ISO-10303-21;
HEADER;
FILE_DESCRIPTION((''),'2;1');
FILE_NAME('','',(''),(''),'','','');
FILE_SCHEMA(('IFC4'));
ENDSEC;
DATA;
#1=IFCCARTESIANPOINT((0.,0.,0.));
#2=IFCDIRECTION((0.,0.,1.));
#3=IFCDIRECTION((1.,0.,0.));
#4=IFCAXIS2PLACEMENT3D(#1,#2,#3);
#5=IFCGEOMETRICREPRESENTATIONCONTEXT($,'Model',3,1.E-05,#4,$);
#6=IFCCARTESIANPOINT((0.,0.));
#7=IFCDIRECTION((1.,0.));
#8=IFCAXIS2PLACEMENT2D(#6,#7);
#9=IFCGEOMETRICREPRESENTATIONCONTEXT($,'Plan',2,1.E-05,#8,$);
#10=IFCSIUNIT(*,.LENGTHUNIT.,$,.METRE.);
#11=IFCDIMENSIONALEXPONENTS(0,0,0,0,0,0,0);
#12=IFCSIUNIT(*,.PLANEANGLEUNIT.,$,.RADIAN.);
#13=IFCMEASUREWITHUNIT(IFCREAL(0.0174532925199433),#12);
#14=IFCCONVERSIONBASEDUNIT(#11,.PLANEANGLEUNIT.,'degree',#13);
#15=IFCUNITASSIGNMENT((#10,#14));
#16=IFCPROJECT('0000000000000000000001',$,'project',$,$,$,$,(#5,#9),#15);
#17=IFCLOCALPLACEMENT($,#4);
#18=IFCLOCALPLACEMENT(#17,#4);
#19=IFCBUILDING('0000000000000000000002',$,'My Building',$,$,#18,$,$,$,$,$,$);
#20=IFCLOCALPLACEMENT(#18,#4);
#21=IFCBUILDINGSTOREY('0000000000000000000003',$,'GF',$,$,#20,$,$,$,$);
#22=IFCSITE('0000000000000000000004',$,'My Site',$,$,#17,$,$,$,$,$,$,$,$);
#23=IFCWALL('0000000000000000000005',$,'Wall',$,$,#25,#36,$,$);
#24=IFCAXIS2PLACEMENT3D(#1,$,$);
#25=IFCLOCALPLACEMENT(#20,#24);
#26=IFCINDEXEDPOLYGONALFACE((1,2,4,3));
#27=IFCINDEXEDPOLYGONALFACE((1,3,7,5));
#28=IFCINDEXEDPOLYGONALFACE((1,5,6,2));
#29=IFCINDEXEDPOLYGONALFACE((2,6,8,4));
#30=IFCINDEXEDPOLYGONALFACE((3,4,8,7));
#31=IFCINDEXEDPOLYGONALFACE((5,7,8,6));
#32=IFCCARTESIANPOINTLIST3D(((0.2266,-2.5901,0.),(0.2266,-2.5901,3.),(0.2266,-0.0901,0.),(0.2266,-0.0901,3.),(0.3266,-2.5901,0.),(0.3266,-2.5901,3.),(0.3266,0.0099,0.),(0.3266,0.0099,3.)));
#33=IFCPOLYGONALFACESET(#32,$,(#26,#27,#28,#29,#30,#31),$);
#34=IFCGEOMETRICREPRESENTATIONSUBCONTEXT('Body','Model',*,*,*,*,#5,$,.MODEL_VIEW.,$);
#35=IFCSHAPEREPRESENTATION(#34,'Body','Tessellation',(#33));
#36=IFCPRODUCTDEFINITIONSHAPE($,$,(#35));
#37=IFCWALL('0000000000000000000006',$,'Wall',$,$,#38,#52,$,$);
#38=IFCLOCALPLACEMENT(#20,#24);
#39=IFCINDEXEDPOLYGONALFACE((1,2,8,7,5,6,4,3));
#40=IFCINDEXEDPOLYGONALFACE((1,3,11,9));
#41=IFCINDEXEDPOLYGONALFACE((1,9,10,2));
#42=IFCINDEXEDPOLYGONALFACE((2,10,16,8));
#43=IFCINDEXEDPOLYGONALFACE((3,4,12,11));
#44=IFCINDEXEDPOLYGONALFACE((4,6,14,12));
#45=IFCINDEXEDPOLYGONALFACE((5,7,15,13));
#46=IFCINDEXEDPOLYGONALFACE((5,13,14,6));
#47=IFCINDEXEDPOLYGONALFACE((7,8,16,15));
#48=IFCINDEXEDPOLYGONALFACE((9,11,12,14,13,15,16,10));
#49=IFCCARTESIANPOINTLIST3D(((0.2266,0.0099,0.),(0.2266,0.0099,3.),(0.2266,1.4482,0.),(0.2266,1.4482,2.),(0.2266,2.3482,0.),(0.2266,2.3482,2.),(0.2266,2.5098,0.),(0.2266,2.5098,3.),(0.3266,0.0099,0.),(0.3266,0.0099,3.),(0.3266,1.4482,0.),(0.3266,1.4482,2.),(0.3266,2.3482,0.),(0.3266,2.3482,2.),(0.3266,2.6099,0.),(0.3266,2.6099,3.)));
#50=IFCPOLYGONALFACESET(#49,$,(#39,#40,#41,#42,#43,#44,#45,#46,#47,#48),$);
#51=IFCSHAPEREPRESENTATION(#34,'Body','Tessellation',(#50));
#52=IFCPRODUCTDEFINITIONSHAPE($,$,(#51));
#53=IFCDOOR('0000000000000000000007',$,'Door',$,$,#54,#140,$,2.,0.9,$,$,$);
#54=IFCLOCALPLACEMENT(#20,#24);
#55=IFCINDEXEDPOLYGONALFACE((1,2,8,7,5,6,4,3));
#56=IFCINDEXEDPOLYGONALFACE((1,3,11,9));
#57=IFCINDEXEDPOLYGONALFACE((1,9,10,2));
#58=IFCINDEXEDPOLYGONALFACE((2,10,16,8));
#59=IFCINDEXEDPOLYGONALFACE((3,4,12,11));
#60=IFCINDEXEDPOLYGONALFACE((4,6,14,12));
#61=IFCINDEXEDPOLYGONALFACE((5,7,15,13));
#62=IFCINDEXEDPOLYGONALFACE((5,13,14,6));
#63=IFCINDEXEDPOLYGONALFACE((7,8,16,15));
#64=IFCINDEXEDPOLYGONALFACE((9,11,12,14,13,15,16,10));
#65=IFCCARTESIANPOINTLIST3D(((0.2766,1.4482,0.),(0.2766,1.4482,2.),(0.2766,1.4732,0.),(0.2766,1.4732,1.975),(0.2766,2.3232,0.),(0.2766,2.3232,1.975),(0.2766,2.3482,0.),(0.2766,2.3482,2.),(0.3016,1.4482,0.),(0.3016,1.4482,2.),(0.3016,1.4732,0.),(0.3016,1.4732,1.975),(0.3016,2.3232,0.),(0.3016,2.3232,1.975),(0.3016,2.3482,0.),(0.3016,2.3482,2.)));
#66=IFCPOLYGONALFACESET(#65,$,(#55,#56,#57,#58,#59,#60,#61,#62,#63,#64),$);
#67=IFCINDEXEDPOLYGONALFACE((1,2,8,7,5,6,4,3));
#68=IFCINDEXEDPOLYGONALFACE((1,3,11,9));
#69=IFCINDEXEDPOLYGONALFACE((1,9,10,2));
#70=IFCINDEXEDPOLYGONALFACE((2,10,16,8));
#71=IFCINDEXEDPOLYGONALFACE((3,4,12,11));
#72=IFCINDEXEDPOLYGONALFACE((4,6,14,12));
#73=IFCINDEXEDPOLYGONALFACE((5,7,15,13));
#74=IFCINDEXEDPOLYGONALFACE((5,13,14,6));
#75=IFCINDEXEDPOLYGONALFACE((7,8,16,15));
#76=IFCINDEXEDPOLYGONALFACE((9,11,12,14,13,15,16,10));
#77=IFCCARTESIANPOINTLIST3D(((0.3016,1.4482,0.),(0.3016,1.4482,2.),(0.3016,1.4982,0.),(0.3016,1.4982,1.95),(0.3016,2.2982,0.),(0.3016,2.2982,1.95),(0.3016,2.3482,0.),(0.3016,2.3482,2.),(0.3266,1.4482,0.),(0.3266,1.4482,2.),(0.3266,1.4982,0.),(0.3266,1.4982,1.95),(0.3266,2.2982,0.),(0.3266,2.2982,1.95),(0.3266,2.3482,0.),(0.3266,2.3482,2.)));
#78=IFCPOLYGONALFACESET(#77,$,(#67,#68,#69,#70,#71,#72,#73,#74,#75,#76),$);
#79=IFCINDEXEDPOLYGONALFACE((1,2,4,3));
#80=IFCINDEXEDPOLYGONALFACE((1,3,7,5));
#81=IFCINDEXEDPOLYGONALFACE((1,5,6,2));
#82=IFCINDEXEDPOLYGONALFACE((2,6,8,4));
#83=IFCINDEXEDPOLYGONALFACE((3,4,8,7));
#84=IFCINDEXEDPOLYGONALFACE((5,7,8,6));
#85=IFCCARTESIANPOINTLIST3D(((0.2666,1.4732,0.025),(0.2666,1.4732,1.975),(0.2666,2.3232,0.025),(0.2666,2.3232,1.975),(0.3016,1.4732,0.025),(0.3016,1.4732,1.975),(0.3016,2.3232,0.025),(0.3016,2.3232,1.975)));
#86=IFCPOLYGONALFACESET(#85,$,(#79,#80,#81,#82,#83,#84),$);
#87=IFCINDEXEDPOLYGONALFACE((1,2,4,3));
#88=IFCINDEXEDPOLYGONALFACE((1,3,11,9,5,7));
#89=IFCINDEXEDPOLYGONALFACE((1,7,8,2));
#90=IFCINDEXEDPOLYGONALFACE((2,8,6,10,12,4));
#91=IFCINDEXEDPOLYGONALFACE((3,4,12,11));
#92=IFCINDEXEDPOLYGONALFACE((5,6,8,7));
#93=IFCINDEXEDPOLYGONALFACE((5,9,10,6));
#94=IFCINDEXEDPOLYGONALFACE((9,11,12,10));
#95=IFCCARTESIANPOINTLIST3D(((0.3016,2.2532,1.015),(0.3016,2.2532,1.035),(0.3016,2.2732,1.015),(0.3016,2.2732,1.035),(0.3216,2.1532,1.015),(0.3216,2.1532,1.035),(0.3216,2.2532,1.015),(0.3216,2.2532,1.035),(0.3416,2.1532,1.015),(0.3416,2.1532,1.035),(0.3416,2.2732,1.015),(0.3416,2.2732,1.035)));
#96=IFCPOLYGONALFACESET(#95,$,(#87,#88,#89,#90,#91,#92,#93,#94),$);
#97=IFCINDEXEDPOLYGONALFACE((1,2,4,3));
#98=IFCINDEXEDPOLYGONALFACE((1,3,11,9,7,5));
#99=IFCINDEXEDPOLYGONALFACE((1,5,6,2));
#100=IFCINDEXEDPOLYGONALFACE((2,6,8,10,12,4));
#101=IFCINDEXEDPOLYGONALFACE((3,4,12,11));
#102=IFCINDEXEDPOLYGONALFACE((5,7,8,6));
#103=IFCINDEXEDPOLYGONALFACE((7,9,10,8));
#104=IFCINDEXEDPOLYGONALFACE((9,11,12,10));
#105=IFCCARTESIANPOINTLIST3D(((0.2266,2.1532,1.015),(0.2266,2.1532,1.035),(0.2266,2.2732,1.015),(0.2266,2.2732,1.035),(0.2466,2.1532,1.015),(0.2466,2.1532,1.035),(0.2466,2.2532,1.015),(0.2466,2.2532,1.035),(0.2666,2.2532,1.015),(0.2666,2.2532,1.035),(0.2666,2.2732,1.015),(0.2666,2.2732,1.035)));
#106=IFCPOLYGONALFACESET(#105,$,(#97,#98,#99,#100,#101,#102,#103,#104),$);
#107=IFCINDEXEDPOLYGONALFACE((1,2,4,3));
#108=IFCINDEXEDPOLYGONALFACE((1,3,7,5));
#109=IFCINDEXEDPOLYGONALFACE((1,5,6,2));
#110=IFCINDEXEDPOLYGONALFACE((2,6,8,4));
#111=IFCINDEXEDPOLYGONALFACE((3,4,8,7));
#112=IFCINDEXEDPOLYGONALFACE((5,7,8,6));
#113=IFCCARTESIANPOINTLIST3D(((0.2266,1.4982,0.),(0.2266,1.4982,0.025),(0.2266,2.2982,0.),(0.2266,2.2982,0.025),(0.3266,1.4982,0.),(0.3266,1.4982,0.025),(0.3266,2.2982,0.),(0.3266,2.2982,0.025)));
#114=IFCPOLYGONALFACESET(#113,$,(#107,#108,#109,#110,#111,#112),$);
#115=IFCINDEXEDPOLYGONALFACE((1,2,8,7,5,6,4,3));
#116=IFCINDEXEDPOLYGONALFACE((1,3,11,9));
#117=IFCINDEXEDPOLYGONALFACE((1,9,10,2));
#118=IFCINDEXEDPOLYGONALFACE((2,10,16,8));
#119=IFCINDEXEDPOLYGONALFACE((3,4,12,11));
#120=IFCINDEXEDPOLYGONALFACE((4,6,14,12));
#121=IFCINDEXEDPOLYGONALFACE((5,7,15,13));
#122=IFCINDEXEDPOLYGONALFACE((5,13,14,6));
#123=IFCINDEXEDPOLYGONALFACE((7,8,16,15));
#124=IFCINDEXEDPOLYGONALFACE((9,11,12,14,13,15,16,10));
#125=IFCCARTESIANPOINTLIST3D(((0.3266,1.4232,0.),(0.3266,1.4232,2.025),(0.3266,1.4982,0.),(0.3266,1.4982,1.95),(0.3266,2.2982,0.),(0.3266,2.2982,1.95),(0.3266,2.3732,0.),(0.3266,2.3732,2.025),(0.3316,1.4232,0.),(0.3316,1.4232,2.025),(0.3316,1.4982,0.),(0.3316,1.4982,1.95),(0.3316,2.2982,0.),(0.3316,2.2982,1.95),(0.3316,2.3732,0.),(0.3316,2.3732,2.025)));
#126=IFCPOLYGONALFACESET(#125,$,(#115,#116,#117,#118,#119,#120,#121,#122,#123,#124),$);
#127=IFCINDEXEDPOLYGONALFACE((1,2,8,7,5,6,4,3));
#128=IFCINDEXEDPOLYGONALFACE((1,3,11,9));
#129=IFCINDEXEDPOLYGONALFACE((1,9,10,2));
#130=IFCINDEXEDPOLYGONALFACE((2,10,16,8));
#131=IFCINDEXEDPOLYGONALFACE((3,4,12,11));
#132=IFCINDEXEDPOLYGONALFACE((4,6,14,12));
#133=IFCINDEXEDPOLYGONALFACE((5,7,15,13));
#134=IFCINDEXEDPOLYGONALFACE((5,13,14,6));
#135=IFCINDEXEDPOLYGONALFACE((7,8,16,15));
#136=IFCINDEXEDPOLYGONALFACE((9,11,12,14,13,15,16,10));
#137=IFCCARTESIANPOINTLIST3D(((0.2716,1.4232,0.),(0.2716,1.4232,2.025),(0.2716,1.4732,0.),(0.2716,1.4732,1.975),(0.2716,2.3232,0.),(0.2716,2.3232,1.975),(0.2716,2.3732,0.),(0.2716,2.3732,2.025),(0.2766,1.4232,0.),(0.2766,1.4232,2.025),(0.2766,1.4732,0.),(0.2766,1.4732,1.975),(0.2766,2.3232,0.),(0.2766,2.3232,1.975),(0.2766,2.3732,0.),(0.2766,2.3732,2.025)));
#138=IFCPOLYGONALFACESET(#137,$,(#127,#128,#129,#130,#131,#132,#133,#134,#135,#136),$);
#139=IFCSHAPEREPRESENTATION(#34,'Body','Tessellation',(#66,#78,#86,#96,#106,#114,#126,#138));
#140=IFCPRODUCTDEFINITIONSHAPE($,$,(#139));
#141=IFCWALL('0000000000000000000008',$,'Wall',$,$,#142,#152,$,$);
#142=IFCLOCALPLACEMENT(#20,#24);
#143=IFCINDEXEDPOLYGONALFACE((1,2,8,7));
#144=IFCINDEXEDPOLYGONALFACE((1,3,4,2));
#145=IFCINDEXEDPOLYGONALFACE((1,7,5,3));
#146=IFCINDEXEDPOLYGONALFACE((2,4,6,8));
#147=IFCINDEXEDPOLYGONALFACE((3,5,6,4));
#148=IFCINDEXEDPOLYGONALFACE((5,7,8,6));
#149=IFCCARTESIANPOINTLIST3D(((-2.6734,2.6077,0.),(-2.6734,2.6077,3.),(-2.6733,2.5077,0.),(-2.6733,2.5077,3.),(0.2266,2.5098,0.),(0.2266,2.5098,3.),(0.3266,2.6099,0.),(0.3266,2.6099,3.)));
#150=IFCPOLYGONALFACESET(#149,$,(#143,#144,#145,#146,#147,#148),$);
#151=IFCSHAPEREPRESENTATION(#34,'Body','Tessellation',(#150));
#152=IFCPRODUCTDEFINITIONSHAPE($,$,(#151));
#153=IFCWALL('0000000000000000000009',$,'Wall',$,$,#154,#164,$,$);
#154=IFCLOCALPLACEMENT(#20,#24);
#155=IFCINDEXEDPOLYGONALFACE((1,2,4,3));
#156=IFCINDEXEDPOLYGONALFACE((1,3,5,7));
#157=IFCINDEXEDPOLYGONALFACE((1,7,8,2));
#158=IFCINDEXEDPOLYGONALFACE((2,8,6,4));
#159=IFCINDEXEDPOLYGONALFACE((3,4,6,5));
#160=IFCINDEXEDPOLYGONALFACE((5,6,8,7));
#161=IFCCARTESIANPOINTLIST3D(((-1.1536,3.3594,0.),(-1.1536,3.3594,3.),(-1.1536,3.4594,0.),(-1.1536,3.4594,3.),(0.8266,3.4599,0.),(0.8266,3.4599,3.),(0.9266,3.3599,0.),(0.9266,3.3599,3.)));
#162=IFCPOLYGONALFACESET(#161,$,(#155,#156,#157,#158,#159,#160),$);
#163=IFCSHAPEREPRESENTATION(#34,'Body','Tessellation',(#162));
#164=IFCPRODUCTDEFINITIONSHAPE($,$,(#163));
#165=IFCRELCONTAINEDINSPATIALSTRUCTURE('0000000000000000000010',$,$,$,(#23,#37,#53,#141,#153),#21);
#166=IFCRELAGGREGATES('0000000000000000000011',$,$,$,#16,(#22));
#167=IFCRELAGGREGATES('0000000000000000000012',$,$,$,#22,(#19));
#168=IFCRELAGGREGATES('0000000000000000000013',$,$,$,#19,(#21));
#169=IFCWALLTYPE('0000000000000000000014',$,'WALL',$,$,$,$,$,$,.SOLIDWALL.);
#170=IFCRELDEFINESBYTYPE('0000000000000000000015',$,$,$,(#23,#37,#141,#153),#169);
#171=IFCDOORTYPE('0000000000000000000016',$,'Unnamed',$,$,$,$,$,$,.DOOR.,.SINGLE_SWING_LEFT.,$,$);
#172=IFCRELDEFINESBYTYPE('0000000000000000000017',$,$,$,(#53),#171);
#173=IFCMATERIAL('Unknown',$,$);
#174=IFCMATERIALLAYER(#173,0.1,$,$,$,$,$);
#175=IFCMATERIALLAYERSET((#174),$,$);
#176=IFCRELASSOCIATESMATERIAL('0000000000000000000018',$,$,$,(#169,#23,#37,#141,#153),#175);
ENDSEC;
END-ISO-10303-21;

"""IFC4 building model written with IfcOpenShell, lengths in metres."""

from ifc_helpers import new_model, entity, si_unit, converted_unit, frame, origin_with_axes, origin_2d_with_axis, place, context, subcontext, project, spatial, line, indexed_curve, outline, extrude, shape, source, transform, mapped, material, layer, layer_set, layer_usage, type_object, type_shapes, element, fill, save


model = new_model("IFC4")

# Units and contexts
model_context = context("Model", 3, precision=1e-05, world=origin_with_axes())
plan_context = context("Plan", 2, precision=1e-05, world=origin_2d_with_axis())
body_context_1 = subcontext(model_context, "Body", "Model", "MODEL_VIEW")
body_context_2 = subcontext(plan_context, "Body", "Plan", "PLAN_VIEW")
ifc_project = project(units=[si_unit("LENGTHUNIT", "METRE"), converted_unit("PLANEANGLEUNIT", "degree", entity("IfcReal", 0.0174532925199433), si_unit("PLANEANGLEUNIT", "RADIAN"), dimensions=[0, 0, 0, 0, 0, 0, 0])], contexts=[model_context, plan_context])

# Site, building, storey
site_placement = place(None, origin_with_axes())
site = spatial("IfcSite", under=ifc_project, at=site_placement, Name="My Site")
building_placement = place(site_placement, origin_with_axes())
building = spatial("IfcBuilding", under=site, at=building_placement, Name="My Building")
storey_placement = place(building_placement, origin_with_axes())
storey = spatial("IfcBuildingStorey", under=building, at=storey_placement, Name="GF")

# Shared definitions
ifc_material = material(Name="Unknown")

# Shared definitions
ifc_layer_1 = layer(ifc_material, 0.1)
ifc_layer_set_1 = layer_set([ifc_layer_1])
wall_type = type_object("IfcWallType", Name="WALL", PredefinedType="SOLIDWALL", material=ifc_layer_set_1)
shared_shape_1 = source(origin_with_axes(), body_context_1, "Body", "SweptSolid", [
    extrude(outline(indexed_curve([(0.0, 0.0), (0.9, 0.0), (0.9, 2.0), (0.0, 2.0)], segments=[line(1, 2, 3, 4, 1)])), frame((0.0, -0.6, 0.0), z_axis=(0.0, -1.0, 0.0), x_axis=(1.0, 0.0, 0.0)), (0.0, 0.0, -1.0), 1.2),
])
door_type = type_object("IfcDoorType", Name="Unnamed", OperationType="SINGLE_SWING_LEFT", PredefinedType="DOOR")
shared_shape_2 = source(origin_with_axes(), body_context_1, "Body", "SweptSolid", [
    extrude(outline(indexed_curve([(0.0, 0.0), (0.0, 2.0), (0.9, 2.0), (0.9, 0.0), (0.875, 0.0), (0.875, 1.975), (0.025, 1.975), (0.025, 0.0)], segments=[line(1, 2, 3, 4, 5, 6, 7, 8, 1)])), frame((0.0, 0.025, 0.0), z_axis=(0.0, -1.0, 0.0), x_axis=(1.0, 0.0, 0.0)), (0.0, 0.0, -1.0), 0.025),
    extrude(outline(indexed_curve([(0.0, 0.0), (0.0, 2.0), (0.9, 2.0), (0.9, 0.0), (0.85, 0.0), (0.85, 1.95), (0.05, 1.95), (0.05, 0.0)], segments=[line(1, 2, 3, 4, 5, 6, 7, 8, 1)])), frame((0.0, 0.0, 0.0), z_axis=(0.0, -1.0, 0.0), x_axis=(1.0, 0.0, 0.0)), (0.0, 0.0, -1.0), 0.025),
    extrude(outline(indexed_curve([(0.0, 0.0), (0.85, 0.0), (0.85, 0.035), (0.0, 0.035)], segments=[line(1, 2, 3, 4, 1)])), frame((0.025, 0.025, 0.025), z_axis=(0.0, 0.0, 1.0), x_axis=(1.0, 0.0, 0.0)), (0.0, 0.0, 1.0), 1.95),
    extrude(outline(indexed_curve([(0.0, 0.0), (0.0, -0.04), (-0.12, -0.04), (-0.12, -0.02), (-0.02, -0.02), (-0.02, 0.0)], segments=[line(1, 2, 3, 4, 5, 6, 1)])), frame((0.825, 0.025, 1.015), z_axis=(0.0, 0.0, 1.0), x_axis=(1.0, 0.0, 0.0)), (0.0, 0.0, 1.0), 0.02),
    extrude(outline(indexed_curve([(0.0, 0.0), (0.0, 0.04), (-0.12, 0.04), (-0.12, 0.02), (-0.02, 0.02), (-0.02, 0.0)], segments=[line(1, 2, 3, 4, 5, 6, 1)])), frame((0.825, 0.06, 1.015), z_axis=(0.0, 0.0, 1.0), x_axis=(1.0, 0.0, 0.0)), (0.0, 0.0, 1.0), 0.02),
    extrude(outline(indexed_curve([(0.0, 0.0), (0.8, 0.0), (0.8, 0.1), (0.0, 0.1)], segments=[line(1, 2, 3, 4, 1)])), frame((0.05, 0.0, 0.0), z_axis=(0.0, 0.0, 1.0), x_axis=(1.0, 0.0, 0.0)), (0.0, 0.0, 1.0), 0.025),
    extrude(outline(indexed_curve([(0.0, 0.0), (0.0, 2.025), (0.95, 2.025), (0.95, 0.0), (0.875, 0.0), (0.875, 1.95), (0.075, 1.95), (0.075, 0.0)], segments=[line(1, 2, 3, 4, 5, 6, 7, 8, 1)])), frame((-0.025, -0.005, 0.0), z_axis=(0.0, -1.0, 0.0), x_axis=(1.0, 0.0, 0.0)), (0.0, 0.0, -1.0), 0.005),
    extrude(outline(indexed_curve([(0.0, 0.0), (0.0, 2.025), (0.95, 2.025), (0.95, 0.0), (0.9, 0.0), (0.9, 1.975), (0.05, 1.975), (0.05, 0.0)], segments=[line(1, 2, 3, 4, 5, 6, 7, 8, 1)])), frame((-0.025, 0.05, 0.0), z_axis=(0.0, -1.0, 0.0), x_axis=(1.0, 0.0, 0.0)), (0.0, 0.0, -1.0), 0.005),
])
shared_shape_3 = source(origin_with_axes(), body_context_2, "Body", "Curve2D", [
    entity("IfcIndexedPolyCurve", entity("IfcCartesianPointList2D", [[0.0, 0.0], [0.0, 0.05], [0.025, 0.05], [0.025, 0.025], [0.05, 0.025], [0.05, 0.0]]), [entity("IfcLineIndex", [1, 2, 3, 4, 5, 6, 1])]),
    entity("IfcIndexedPolyCurve", entity("IfcCartesianPointList2D", [[0.9, 0.0], [0.9, 0.05], [0.875, 0.05], [0.875, 0.025], [0.85, 0.025], [0.85, 0.0]]), [entity("IfcLineIndex", [1, 2, 3, 4, 5, 6, 1])]),
    entity("IfcTrimmedCurve", entity("IfcEllipse", entity("IfcAxis2Placement2D", entity("IfcCartesianPoint", [0.06, 0.05]), entity("IfcDirection", [1.0, 0.0])), 0.815, 0.85), [entity("IfcCartesianPoint", [0.875, 0.05])], [entity("IfcCartesianPoint", [0.06, 0.9])], True, "CARTESIAN"),
    entity("IfcIndexedPolyCurve", entity("IfcCartesianPointList2D", [[0.025, 0.05], [0.06, 0.05], [0.06, 0.9], [0.025, 0.9]]), [entity("IfcLineIndex", [1, 2, 3, 4, 1])]),
])
type_shapes(door_type, [shared_shape_2, shared_shape_3])

# Wall
ifc_layer_usage_1 = layer_usage(ifc_layer_set_1, "AXIS2", "POSITIVE", 0.0)
wall_1_placement = place(storey_placement, frame((0.2266, -0.0901, 0.0), z_axis=(0.0, 0.0, 1.0), x_axis=(0.0, -1.0, 0.0)))
element("IfcWall", 1, at=wall_1_placement, inside=storey, type_object=wall_type, material=ifc_layer_usage_1, Name="Wall", context=body_context_1, shape_type="SweptSolid", body=[
    extrude(outline(indexed_curve([(0.0, 0.0), (-0.1, 0.1), (2.5, 0.1), (2.5, 0.0)], segments=[line(1, 2, 3, 4, 1)])), origin_with_axes(), (0.0, 0.0, 1.0), 3.0),
])

# Wall, opening, door
ifc_layer_usage_2 = layer_usage(ifc_layer_set_1, "AXIS2", "POSITIVE", 0.0)
wall_2_placement = place(storey_placement, frame((0.3266, 0.0099, 0.0), z_axis=(0.0, 0.0, 1.0), x_axis=(0.0, 1.0, 0.0)))
wall_2 = element("IfcWall", 2, at=wall_2_placement, inside=storey, type_object=wall_type, material=ifc_layer_usage_2, Name="Wall", context=body_context_1, shape_type="SweptSolid", body=[
    extrude(outline(indexed_curve([(0.0, 0.0), (0.0, 0.1), (2.4999, 0.1), (2.6, 0.0)], segments=[line(1, 2, 3, 4, 1)])), origin_with_axes(), (0.0, 0.0, 1.0), 3.0),
])
opening_1_placement = place(wall_2_placement, frame((1.4383, 0.0, 0.0), z_axis=(0.0, 0.0, 1.0), x_axis=(1.0, 0.0, 0.0)))
opening_1 = element("IfcOpeningElement", 3, at=opening_1_placement, cuts=wall_2, PredefinedType="OPENING", context=body_context_1, shape_type="MappedRepresentation", body=[
    mapped(shared_shape_1, transform((0.0, 0.0, 0.0), x_axis=(1.0, 0.0, 0.0), y_axis=(0.0, 1.0, 0.0), z_axis=(0.0, 0.0, 1.0), scale=1.0)),
])
door_1_placement = place(opening_1_placement, frame((0.0, 0.0, 0.0), z_axis=(0.0, 0.0, 1.0), x_axis=(1.0, 0.0, 0.0)))
door_1 = element("IfcDoor", 4, at=door_1_placement, inside=storey, type_object=door_type, Name="Door", OverallHeight=2.0, OverallWidth=0.9, shapes=[
    shape(body_context_1, "Body", "MappedRepresentation", [mapped(shared_shape_2, transform((0.0, 0.0, 0.0), x_axis=(1.0, 0.0, 0.0), y_axis=(0.0, 1.0, 0.0), z_axis=(0.0, 0.0, 1.0), scale=1.0))]),
    shape(body_context_2, "Body", "MappedRepresentation", [mapped(shared_shape_3, transform((0.0, 0.0, 0.0), x_axis=(1.0, 0.0, 0.0), y_axis=(0.0, 1.0, 0.0), z_axis=(0.0, 0.0, 1.0), scale=1.0))]),
])
fill(opening_1, door_1)

# Walls
ifc_layer_usage_3 = layer_usage(ifc_layer_set_1, "AXIS2", "POSITIVE", 0.0)
wall_3_placement = place(storey_placement, frame((0.3266, 2.6099, 0.0), z_axis=(0.0, 0.0, 1.0), x_axis=(-1.0, -0.000723, 0.0)))
element("IfcWall", 5, at=wall_3_placement, inside=storey, type_object=wall_type, material=ifc_layer_usage_3, Name="Wall", context=body_context_1, shape_type="SweptSolid", body=[
    extrude(outline(indexed_curve([(0.0, 0.0), (0.1001, 0.1), (3.0, 0.1), (3.0, 0.0)], segments=[line(1, 2, 3, 4, 1)])), origin_with_axes(), (0.0, 0.0, 1.0), 3.0),
])
ifc_layer_usage_4 = layer_usage(ifc_layer_set_1, "AXIS2", "POSITIVE", 0.0)
wall_4_placement = place(storey_placement, frame((0.8266, 3.4599, 0.0), z_axis=(0.0, 0.0, 1.0), x_axis=(-1.0, -0.000229, 0.0)))
element("IfcWall", 6, at=wall_4_placement, inside=storey, type_object=wall_type, material=ifc_layer_usage_4, Name="Wall", context=body_context_1, shape_type="SweptSolid", body=[
    extrude(outline(indexed_curve([(0.0, 0.0), (-0.1, 0.1), (1.9802, 0.1), (1.9802, 0.0)], segments=[line(1, 2, 3, 4, 1)])), origin_with_axes(), (0.0, 0.0, 1.0), 3.0),
])

save(model, "model.ifc")
